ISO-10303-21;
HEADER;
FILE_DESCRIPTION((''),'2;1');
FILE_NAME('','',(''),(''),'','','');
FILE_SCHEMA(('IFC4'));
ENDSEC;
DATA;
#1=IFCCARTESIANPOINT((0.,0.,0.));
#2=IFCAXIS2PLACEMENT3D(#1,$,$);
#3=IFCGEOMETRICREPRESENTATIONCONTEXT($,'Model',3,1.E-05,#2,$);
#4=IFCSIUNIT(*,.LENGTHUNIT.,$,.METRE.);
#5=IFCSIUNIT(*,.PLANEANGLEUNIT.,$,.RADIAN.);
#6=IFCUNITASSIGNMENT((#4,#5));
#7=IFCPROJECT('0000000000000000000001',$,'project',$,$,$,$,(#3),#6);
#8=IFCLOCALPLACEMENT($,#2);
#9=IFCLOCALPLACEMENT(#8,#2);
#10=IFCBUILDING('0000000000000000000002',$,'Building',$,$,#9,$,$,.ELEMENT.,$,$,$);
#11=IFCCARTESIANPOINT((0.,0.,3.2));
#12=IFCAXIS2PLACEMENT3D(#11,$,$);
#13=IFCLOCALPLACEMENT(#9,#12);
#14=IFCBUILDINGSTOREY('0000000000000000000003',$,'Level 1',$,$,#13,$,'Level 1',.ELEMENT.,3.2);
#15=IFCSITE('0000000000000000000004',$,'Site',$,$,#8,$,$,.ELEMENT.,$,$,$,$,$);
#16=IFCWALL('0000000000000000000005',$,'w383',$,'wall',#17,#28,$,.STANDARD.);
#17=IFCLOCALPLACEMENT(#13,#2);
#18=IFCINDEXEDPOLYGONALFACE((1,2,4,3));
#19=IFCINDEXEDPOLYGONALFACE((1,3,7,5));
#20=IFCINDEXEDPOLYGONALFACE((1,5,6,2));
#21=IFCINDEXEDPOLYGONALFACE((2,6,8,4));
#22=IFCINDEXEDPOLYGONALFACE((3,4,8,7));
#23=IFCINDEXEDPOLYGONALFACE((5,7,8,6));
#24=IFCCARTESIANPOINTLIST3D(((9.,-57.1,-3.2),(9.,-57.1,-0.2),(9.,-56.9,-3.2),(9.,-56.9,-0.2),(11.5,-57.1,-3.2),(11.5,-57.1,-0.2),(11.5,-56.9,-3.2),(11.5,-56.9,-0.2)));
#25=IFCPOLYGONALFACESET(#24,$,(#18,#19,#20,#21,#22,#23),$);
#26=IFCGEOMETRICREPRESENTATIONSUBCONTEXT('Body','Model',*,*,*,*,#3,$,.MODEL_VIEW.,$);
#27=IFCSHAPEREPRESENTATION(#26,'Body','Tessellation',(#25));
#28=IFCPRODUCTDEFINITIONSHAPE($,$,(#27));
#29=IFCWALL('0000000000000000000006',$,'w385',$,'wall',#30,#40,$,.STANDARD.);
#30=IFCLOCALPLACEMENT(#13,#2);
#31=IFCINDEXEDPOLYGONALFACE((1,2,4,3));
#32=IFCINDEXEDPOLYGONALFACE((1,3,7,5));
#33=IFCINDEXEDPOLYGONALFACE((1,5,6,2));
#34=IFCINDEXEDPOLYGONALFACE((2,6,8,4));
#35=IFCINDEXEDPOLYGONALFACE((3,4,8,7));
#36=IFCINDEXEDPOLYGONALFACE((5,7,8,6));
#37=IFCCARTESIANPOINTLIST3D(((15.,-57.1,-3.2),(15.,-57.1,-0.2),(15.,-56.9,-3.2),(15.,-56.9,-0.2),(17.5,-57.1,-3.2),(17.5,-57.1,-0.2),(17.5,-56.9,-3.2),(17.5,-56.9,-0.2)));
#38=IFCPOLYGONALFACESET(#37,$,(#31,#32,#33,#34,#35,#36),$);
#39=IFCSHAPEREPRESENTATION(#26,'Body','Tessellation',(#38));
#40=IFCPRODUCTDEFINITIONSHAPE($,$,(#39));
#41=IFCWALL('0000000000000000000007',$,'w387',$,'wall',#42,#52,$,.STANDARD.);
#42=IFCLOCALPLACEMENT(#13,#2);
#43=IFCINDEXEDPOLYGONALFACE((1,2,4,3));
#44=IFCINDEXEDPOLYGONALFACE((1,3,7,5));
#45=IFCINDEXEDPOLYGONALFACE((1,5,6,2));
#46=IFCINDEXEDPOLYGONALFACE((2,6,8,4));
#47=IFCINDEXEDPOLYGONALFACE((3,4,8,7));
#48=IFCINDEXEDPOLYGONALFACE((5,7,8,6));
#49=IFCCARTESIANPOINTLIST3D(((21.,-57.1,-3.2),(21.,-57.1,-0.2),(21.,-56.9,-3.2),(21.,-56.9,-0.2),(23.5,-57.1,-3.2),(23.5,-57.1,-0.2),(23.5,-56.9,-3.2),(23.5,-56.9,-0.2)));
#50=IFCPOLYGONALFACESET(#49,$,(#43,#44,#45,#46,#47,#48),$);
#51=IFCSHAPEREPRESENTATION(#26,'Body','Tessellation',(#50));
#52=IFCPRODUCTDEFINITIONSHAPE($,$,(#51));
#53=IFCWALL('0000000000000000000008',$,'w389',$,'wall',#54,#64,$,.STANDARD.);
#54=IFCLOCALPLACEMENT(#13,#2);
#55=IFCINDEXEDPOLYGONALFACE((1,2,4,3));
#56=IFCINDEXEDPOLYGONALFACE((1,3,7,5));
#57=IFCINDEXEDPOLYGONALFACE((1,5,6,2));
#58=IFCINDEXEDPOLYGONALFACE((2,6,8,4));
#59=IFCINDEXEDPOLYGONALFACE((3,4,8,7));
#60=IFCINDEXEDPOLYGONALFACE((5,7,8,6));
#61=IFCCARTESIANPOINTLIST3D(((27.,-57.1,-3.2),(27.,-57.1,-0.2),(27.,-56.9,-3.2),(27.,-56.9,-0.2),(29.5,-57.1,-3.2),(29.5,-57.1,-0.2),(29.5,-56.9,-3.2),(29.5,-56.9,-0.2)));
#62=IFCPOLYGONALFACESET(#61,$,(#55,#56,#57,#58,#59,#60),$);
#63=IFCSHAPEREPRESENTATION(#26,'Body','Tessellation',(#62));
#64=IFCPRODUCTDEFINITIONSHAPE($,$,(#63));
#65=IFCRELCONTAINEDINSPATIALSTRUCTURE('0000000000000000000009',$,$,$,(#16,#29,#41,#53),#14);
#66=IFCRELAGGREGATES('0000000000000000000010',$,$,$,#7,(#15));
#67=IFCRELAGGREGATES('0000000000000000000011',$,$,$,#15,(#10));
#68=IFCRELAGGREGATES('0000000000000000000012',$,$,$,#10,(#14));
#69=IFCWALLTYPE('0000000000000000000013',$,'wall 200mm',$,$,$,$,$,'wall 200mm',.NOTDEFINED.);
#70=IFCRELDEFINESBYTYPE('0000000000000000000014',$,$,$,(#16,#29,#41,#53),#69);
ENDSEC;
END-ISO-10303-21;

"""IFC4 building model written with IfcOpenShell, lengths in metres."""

from ifc_helpers import new_model, si_unit, frame, frame_2d, origin, place, context, subcontext, project, spatial, rectangle, extrude, type_object, element, save


model = new_model("IFC4")

# Units and contexts
model_context = context("Model", 3, precision=1e-05, world=origin())
body_context = subcontext(model_context, "Body", "Model", "MODEL_VIEW")
ifc_project = project(units=[si_unit("LENGTHUNIT", "METRE"), si_unit("PLANEANGLEUNIT", "RADIAN")], contexts=[model_context])

# Site, building, storey
site_placement = place(None, origin())
site = spatial("IfcSite", under=ifc_project, at=site_placement, Name="Site", CompositionType="ELEMENT")
building_placement = place(site_placement, origin())
building = spatial("IfcBuilding", under=site, at=building_placement, Name="Building", CompositionType="ELEMENT")
storey_placement = place(building_placement, frame((0.0, 0.0, 3.2)))
storey = spatial("IfcBuildingStorey", under=building, at=storey_placement, Name="Level 1", LongName="Level 1", CompositionType="ELEMENT", Elevation=3.2)

# Walls
wall_type = type_object("IfcWallType", Name="wall 200mm", ElementType="wall 200mm", PredefinedType="NOTDEFINED")
for number, where, z_axis, x_axis, name in (
    (1, (9.0, -57.0, -3.2), (0.0, 0.0, 1.0), (1.0, 0.0, 0.0), "w383"),
    (2, (15.0, -57.0, -3.2), (0.0, 0.0, 1.0), (1.0, 0.0, 0.0), "w385"),
    (3, (21.0, -57.0, -3.2), (0.0, 0.0, 1.0), (1.0, 0.0, 0.0), "w387"),
    (4, (27.0, -57.0, -3.2), (0.0, 0.0, 1.0), (1.0, 0.0, 0.0), "w389"),
):
    element("IfcWall", number, at=place(storey_placement, frame(where, z_axis=z_axis, x_axis=x_axis)), inside=storey, type_object=wall_type, Name=name, ObjectType="wall", PredefinedType="STANDARD", context=body_context, shape_type="SweptSolid", body=[
        extrude(rectangle(XDim=2.5, YDim=0.2, at=frame_2d((1.25, 0.0))), origin(), (0.0, 0.0, 1.0), 3.0),
    ])

save(model, "model.ifc")
